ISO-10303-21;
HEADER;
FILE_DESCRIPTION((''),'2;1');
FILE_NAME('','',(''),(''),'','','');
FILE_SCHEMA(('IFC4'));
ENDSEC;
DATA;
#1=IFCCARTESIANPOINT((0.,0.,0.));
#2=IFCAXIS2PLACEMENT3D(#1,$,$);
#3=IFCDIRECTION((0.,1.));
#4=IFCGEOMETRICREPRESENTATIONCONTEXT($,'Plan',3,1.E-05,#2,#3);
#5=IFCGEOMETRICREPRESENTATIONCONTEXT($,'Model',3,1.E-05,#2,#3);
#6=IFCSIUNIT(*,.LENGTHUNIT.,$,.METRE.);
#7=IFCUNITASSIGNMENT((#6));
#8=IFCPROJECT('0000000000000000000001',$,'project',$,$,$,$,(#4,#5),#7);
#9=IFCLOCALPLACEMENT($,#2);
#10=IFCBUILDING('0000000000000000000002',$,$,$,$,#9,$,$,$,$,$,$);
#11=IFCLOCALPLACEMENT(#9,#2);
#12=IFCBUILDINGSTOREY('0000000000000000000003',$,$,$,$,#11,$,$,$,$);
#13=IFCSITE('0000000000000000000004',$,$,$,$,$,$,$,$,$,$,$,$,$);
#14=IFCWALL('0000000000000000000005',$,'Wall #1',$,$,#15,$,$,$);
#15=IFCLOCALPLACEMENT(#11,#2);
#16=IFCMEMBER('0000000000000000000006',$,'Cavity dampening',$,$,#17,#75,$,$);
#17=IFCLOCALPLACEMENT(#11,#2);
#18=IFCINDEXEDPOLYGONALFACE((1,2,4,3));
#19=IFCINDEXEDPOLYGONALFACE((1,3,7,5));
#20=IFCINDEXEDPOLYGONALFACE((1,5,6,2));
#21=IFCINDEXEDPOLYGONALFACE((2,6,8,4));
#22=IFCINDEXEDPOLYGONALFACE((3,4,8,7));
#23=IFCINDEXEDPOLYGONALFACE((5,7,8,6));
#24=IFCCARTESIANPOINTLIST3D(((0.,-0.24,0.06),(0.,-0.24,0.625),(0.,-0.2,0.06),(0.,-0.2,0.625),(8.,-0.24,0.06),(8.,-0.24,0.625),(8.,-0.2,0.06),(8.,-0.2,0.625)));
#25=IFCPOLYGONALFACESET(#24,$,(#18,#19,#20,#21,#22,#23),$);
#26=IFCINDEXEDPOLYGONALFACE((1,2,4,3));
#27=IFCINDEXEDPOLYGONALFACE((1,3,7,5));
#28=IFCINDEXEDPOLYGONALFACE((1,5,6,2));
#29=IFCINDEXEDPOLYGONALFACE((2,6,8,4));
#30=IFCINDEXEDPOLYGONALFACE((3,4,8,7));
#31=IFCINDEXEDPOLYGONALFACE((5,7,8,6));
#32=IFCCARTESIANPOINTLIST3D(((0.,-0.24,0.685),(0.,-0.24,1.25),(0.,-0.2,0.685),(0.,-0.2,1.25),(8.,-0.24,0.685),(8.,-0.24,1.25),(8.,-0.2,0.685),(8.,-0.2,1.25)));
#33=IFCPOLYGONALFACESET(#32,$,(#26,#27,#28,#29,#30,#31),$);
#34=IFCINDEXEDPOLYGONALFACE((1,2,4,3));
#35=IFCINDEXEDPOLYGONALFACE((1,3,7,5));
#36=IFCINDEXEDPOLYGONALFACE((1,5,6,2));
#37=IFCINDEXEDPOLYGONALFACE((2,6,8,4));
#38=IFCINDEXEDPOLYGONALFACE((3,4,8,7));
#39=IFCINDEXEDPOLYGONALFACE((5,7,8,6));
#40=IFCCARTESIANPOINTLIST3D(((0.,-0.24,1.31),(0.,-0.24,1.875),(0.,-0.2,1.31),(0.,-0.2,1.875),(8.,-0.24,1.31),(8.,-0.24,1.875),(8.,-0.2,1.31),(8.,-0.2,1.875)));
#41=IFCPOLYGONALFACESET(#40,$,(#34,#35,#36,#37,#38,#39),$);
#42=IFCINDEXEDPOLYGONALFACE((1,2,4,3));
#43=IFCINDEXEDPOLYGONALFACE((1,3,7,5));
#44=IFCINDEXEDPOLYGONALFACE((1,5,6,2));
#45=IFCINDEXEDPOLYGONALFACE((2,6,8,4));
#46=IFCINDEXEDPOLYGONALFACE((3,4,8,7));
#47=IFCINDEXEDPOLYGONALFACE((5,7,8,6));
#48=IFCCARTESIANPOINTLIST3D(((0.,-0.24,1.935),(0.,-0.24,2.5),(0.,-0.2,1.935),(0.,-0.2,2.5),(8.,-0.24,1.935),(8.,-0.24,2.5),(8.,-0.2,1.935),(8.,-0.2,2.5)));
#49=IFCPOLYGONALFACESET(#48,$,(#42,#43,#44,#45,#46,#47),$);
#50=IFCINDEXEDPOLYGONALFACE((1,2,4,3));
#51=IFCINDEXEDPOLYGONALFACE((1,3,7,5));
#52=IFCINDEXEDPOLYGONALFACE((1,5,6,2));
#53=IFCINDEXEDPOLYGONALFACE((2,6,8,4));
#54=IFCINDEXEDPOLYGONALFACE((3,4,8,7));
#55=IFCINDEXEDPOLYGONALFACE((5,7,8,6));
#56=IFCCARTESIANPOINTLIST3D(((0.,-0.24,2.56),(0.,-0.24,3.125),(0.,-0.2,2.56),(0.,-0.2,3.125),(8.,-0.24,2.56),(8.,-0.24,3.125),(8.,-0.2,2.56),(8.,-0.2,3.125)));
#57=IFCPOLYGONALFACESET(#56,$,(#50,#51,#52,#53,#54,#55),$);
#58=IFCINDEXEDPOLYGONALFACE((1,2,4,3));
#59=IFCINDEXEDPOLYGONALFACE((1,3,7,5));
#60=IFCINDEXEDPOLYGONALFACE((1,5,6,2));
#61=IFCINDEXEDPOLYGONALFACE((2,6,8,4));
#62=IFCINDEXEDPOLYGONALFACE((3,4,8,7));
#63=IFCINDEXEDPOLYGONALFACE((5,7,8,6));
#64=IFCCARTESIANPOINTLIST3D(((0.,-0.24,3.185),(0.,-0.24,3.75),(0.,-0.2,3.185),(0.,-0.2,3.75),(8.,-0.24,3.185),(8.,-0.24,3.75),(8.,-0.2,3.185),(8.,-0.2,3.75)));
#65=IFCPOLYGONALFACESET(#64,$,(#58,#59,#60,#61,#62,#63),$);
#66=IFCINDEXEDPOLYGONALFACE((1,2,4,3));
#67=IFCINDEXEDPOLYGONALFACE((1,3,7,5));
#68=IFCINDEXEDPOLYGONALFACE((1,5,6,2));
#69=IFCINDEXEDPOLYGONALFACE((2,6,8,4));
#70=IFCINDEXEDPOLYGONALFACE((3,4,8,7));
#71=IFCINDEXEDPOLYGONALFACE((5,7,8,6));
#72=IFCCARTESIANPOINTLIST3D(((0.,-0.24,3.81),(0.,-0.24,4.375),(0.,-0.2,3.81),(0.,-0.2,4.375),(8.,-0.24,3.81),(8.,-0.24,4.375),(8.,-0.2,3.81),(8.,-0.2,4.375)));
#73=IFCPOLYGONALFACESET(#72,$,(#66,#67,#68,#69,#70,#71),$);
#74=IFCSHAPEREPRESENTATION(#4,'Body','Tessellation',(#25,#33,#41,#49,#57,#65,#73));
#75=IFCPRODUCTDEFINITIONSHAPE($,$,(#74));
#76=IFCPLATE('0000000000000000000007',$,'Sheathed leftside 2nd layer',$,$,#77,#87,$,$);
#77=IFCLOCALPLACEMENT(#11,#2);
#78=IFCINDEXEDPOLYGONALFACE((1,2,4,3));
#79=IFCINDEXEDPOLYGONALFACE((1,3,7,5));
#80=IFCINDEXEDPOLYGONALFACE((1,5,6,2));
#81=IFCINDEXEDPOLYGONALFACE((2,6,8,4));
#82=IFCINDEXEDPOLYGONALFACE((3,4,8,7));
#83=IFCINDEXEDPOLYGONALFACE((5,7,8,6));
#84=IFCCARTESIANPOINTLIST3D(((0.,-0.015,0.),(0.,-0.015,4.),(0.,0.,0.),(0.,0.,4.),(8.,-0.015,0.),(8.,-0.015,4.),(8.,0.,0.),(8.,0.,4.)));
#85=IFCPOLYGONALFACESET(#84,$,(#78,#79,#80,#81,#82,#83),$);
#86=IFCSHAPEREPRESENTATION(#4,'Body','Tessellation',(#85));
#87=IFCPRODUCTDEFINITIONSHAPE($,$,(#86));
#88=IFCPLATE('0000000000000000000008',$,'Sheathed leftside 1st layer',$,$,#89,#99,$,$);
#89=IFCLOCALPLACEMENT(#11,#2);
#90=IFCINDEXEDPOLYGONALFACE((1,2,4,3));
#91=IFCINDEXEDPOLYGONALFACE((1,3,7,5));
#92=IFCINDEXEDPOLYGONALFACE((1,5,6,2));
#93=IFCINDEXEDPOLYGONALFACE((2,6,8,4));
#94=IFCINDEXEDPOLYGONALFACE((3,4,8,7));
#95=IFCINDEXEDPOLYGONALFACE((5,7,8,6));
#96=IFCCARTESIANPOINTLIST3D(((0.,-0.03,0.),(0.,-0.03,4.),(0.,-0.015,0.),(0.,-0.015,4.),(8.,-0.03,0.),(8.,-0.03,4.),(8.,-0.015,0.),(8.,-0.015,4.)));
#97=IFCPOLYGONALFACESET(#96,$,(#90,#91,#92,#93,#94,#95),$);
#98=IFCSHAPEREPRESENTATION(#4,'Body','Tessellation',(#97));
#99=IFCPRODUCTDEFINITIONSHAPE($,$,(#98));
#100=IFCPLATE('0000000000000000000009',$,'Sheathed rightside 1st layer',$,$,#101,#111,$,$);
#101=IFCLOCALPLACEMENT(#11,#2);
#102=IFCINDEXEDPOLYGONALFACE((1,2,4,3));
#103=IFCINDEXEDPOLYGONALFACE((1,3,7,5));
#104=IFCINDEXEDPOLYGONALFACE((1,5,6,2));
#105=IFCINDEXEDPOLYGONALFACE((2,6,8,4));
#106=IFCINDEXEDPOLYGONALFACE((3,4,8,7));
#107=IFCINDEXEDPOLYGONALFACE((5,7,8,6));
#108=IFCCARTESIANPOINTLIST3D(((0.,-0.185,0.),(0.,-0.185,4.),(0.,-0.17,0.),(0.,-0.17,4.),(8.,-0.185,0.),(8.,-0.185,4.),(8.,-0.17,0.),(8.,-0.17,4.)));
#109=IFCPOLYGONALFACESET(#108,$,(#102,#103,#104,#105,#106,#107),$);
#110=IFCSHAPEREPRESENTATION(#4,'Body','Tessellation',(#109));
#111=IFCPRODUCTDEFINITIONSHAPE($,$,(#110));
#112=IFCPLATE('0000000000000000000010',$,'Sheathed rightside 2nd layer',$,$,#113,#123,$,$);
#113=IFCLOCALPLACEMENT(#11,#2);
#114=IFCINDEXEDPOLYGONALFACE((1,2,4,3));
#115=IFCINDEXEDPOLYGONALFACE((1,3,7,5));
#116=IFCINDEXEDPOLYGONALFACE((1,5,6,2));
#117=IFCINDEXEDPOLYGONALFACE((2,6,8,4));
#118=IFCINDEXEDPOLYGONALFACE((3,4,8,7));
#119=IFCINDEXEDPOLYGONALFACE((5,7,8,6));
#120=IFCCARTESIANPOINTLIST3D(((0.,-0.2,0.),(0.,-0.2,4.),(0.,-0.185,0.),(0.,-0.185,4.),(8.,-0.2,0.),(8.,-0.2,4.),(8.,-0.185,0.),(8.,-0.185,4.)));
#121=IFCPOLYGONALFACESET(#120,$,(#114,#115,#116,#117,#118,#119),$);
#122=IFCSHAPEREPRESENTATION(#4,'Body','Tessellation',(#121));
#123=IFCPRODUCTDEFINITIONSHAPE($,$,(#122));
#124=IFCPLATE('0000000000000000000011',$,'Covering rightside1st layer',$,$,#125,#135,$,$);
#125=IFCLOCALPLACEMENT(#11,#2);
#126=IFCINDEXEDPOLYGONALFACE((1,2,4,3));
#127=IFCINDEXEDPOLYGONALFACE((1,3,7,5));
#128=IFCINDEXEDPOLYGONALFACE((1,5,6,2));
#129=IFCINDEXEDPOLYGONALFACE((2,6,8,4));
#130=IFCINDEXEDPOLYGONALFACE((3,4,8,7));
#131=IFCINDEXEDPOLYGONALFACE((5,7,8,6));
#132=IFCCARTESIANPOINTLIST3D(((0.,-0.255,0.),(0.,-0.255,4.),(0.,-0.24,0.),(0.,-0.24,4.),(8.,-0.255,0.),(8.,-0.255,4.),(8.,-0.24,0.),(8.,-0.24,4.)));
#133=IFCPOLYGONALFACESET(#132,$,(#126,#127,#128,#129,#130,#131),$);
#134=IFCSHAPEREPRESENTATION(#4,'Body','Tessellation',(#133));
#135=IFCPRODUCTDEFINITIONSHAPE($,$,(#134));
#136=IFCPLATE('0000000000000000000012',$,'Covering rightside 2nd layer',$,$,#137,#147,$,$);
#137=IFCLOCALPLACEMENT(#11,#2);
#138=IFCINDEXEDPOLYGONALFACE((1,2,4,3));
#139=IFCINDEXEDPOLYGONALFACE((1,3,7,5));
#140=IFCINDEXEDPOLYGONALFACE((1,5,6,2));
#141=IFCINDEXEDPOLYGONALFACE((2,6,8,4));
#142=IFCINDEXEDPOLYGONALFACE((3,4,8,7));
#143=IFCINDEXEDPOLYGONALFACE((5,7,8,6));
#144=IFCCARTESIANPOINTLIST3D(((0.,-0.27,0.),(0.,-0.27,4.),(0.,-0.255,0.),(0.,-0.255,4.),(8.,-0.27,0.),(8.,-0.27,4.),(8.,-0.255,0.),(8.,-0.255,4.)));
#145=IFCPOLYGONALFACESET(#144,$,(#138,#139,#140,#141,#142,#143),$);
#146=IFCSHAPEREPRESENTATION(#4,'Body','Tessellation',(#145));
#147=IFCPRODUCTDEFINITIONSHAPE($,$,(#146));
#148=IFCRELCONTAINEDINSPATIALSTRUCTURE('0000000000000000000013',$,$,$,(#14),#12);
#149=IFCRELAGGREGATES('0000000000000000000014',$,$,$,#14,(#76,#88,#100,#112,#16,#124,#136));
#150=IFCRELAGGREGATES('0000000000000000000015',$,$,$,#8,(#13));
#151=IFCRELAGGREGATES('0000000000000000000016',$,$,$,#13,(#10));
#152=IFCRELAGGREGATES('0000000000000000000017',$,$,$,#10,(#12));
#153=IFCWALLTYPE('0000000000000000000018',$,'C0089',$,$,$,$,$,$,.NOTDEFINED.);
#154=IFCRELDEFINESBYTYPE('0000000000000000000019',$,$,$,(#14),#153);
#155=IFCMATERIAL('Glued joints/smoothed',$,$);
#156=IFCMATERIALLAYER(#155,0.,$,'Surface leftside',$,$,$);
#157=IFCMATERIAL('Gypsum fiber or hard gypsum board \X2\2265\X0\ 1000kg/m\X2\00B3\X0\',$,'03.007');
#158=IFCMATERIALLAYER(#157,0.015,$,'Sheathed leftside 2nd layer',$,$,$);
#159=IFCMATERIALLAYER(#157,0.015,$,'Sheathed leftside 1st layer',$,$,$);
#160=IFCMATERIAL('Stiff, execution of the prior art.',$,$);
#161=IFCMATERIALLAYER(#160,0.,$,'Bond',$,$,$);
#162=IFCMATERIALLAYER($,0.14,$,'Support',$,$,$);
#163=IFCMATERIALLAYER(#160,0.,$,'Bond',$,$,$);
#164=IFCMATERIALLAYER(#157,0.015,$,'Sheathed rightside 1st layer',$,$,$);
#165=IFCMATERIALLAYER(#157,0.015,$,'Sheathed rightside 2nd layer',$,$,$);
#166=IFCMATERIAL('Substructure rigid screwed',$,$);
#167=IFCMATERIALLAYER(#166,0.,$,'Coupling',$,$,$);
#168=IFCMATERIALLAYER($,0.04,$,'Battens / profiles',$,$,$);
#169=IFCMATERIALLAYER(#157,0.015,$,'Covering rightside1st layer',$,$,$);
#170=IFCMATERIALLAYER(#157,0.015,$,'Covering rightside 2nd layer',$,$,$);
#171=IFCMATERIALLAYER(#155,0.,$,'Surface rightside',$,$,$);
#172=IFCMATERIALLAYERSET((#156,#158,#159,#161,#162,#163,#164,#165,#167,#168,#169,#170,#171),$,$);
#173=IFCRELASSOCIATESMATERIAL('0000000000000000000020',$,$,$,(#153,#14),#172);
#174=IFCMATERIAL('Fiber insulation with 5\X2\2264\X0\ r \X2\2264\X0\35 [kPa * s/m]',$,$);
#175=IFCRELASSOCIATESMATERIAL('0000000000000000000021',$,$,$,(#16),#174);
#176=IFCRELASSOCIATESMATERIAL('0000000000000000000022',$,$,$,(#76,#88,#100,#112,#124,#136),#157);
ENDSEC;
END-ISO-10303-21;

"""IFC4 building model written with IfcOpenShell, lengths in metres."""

from ifc_helpers import new_model, si_unit, direction, frame, frame_2d, origin, origin_with_axes, place, context, project, spatial, rectangle, extrude, material, layer, layer_set, type_object, element, aggregate, save


model = new_model("IFC4")

# Units and contexts
plan_context = context("Plan", 3, precision=1e-05, world=origin(), true_north=direction((0.0, 1.0)))
model_context = context("Model", 3, precision=1e-05, world=origin(), true_north=direction((0.0, 1.0)))
ifc_project = project(units=[si_unit("LENGTHUNIT", "METRE")], contexts=[plan_context, model_context])

# Site, building, storey
site = spatial("IfcSite", under=ifc_project)
building_placement = place(None, origin())
building = spatial("IfcBuilding", under=site, at=building_placement)
storey_placement = place(building_placement, origin())
storey = spatial("IfcBuildingStorey", under=building, at=storey_placement)

# Wall, member, plates
ifc_material_1 = material(Name="Glued joints/smoothed")
ifc_layer_1 = layer(ifc_material_1, 0.0, Name="Surface leftside")
ifc_material_2 = material(Name="Gypsum fiber or hard gypsum board ≥ 1000kg/m³", Category="03.007")
ifc_layer_2 = layer(ifc_material_2, 0.015, Name="Sheathed leftside 2nd layer")
ifc_layer_3 = layer(ifc_material_2, 0.015, Name="Sheathed leftside 1st layer")
ifc_material_3 = material(Name="Stiff, execution of the prior art.")
ifc_layer_4 = layer(ifc_material_3, 0.0, Name="Bond")
ifc_layer_5 = layer(None, 0.14, Name="Support")
ifc_layer_6 = layer(ifc_material_3, 0.0, Name="Bond")
ifc_layer_7 = layer(ifc_material_2, 0.015, Name="Sheathed rightside 1st layer")
ifc_layer_8 = layer(ifc_material_2, 0.015, Name="Sheathed rightside 2nd layer")
ifc_material_4 = material(Name="Substructure rigid screwed")
ifc_layer_9 = layer(ifc_material_4, 0.0, Name="Coupling")
ifc_layer_10 = layer(None, 0.04, Name="Battens / profiles")
ifc_layer_11 = layer(ifc_material_2, 0.015, Name="Covering rightside1st layer")
ifc_layer_12 = layer(ifc_material_2, 0.015, Name="Covering rightside 2nd layer")
ifc_layer_13 = layer(ifc_material_1, 0.0, Name="Surface rightside")
ifc_layer_set = layer_set([ifc_layer_1, ifc_layer_2, ifc_layer_3, ifc_layer_4, ifc_layer_5, ifc_layer_6, ifc_layer_7, ifc_layer_8, ifc_layer_9, ifc_layer_10, ifc_layer_11, ifc_layer_12, ifc_layer_13])
wall_type = type_object("IfcWallType", Name="C0089", PredefinedType="NOTDEFINED", material=ifc_layer_set)
wall_placement = place(None, frame((0.0, 0.0, 0.0), z_axis=(0.0, -1.0, 0.0), x_axis=(1.0, 0.0, 0.0)))
wall = element("IfcWall", 1, at=wall_placement, inside=storey, type_object=wall_type, material=ifc_layer_set, Name="Wall #1")
ifc_material_5 = material(Name="Fiber insulation with 5≤ r ≤35 [kPa * s/m]")
member_1_placement = place(wall_placement, origin())
member_1 = element("IfcMember", 2, at=member_1_placement, material=ifc_material_5, Name="Cavity dampening", context=plan_context, shape_type="SweptSolid", body=[
    extrude(rectangle(XDim=0.565, YDim=0.04, at=frame_2d((0.2825, 0.02), x_axis=(1.0, 0.0))), frame((0.0, 0.06, 0.2), z_axis=(1.0, 0.0, 0.0), x_axis=(0.0, 1.0, 0.0)), (0.0, 0.0, 1.0), 8.0),
    extrude(rectangle(XDim=0.565, YDim=0.04, at=frame_2d((0.2825, 0.02), x_axis=(1.0, 0.0))), frame((0.0, 0.685, 0.2), z_axis=(1.0, 0.0, 0.0), x_axis=(0.0, 1.0, 0.0)), (0.0, 0.0, 1.0), 8.0),
    extrude(rectangle(XDim=0.565, YDim=0.04, at=frame_2d((0.2825, 0.02), x_axis=(1.0, 0.0))), frame((0.0, 1.31, 0.2), z_axis=(1.0, 0.0, 0.0), x_axis=(0.0, 1.0, 0.0)), (0.0, 0.0, 1.0), 8.0),
    extrude(rectangle(XDim=0.565, YDim=0.04, at=frame_2d((0.2825, 0.02), x_axis=(1.0, 0.0))), frame((0.0, 1.935, 0.2), z_axis=(1.0, 0.0, 0.0), x_axis=(0.0, 1.0, 0.0)), (0.0, 0.0, 1.0), 8.0),
    extrude(rectangle(XDim=0.565, YDim=0.04, at=frame_2d((0.2825, 0.02), x_axis=(1.0, 0.0))), frame((0.0, 2.56, 0.2), z_axis=(1.0, 0.0, 0.0), x_axis=(0.0, 1.0, 0.0)), (0.0, 0.0, 1.0), 8.0),
    extrude(rectangle(XDim=0.565, YDim=0.04, at=frame_2d((0.2825, 0.02), x_axis=(1.0, 0.0))), frame((0.0, 3.185, 0.2), z_axis=(1.0, 0.0, 0.0), x_axis=(0.0, 1.0, 0.0)), (0.0, 0.0, 1.0), 8.0),
    extrude(rectangle(XDim=0.565, YDim=0.04, at=frame_2d((0.2825, 0.02), x_axis=(1.0, 0.0))), frame((0.0, 3.81, 0.2), z_axis=(1.0, 0.0, 0.0), x_axis=(0.0, 1.0, 0.0)), (0.0, 0.0, 1.0), 8.0),
])
plate_1_placement = place(wall_placement, origin())
plate_1 = element("IfcPlate", 3, at=plate_1_placement, material=ifc_material_2, Name="Sheathed leftside 2nd layer", context=plan_context, shape_type="SweptSolid", body=[
    extrude(rectangle(XDim=8.0, YDim=4.0, at=frame_2d((4.0, 2.0), x_axis=(1.0, 0.0))), origin_with_axes(), (0.0, 0.0, 1.0), 0.015),
])
plate_2_placement = place(wall_placement, origin())
plate_2 = element("IfcPlate", 4, at=plate_2_placement, material=ifc_material_2, Name="Sheathed leftside 1st layer", context=plan_context, shape_type="SweptSolid", body=[
    extrude(rectangle(XDim=8.0, YDim=4.0, at=frame_2d((4.0, 2.0), x_axis=(1.0, 0.0))), frame((0.0, 0.0, 0.015), z_axis=(0.0, 0.0, 1.0), x_axis=(1.0, 0.0, 0.0)), (0.0, 0.0, 1.0), 0.015),
])
plate_3_placement = place(wall_placement, origin())
plate_3 = element("IfcPlate", 5, at=plate_3_placement, material=ifc_material_2, Name="Sheathed rightside 1st layer", context=plan_context, shape_type="SweptSolid", body=[
    extrude(rectangle(XDim=8.0, YDim=4.0, at=frame_2d((4.0, 2.0), x_axis=(1.0, 0.0))), frame((0.0, 0.0, 0.17), z_axis=(0.0, 0.0, 1.0), x_axis=(1.0, 0.0, 0.0)), (0.0, 0.0, 1.0), 0.015),
])
plate_4_placement = place(wall_placement, origin())
plate_4 = element("IfcPlate", 6, at=plate_4_placement, material=ifc_material_2, Name="Sheathed rightside 2nd layer", context=plan_context, shape_type="SweptSolid", body=[
    extrude(rectangle(XDim=8.0, YDim=4.0, at=frame_2d((4.0, 2.0), x_axis=(1.0, 0.0))), frame((0.0, 0.0, 0.185), z_axis=(0.0, 0.0, 1.0), x_axis=(1.0, 0.0, 0.0)), (0.0, 0.0, 1.0), 0.015),
])
plate_5_placement = place(wall_placement, origin())
plate_5 = element("IfcPlate", 7, at=plate_5_placement, material=ifc_material_2, Name="Covering rightside1st layer", context=plan_context, shape_type="SweptSolid", body=[
    extrude(rectangle(XDim=8.0, YDim=4.0, at=frame_2d((4.0, 2.0), x_axis=(1.0, 0.0))), frame((0.0, 0.0, 0.24), z_axis=(0.0, 0.0, 1.0), x_axis=(1.0, 0.0, 0.0)), (0.0, 0.0, 1.0), 0.015),
])
plate_6_placement = place(wall_placement, origin())
plate_6 = element("IfcPlate", 8, at=plate_6_placement, material=ifc_material_2, Name="Covering rightside 2nd layer", context=plan_context, shape_type="SweptSolid", body=[
    extrude(rectangle(XDim=8.0, YDim=4.0, at=frame_2d((4.0, 2.0), x_axis=(1.0, 0.0))), frame((0.0, 0.0, 0.255), z_axis=(0.0, 0.0, 1.0), x_axis=(1.0, 0.0, 0.0)), (0.0, 0.0, 1.0), 0.015),
])
aggregate(wall, [plate_1, plate_2, plate_3, plate_4, member_1, plate_5, plate_6])

save(model, "model.ifc")
